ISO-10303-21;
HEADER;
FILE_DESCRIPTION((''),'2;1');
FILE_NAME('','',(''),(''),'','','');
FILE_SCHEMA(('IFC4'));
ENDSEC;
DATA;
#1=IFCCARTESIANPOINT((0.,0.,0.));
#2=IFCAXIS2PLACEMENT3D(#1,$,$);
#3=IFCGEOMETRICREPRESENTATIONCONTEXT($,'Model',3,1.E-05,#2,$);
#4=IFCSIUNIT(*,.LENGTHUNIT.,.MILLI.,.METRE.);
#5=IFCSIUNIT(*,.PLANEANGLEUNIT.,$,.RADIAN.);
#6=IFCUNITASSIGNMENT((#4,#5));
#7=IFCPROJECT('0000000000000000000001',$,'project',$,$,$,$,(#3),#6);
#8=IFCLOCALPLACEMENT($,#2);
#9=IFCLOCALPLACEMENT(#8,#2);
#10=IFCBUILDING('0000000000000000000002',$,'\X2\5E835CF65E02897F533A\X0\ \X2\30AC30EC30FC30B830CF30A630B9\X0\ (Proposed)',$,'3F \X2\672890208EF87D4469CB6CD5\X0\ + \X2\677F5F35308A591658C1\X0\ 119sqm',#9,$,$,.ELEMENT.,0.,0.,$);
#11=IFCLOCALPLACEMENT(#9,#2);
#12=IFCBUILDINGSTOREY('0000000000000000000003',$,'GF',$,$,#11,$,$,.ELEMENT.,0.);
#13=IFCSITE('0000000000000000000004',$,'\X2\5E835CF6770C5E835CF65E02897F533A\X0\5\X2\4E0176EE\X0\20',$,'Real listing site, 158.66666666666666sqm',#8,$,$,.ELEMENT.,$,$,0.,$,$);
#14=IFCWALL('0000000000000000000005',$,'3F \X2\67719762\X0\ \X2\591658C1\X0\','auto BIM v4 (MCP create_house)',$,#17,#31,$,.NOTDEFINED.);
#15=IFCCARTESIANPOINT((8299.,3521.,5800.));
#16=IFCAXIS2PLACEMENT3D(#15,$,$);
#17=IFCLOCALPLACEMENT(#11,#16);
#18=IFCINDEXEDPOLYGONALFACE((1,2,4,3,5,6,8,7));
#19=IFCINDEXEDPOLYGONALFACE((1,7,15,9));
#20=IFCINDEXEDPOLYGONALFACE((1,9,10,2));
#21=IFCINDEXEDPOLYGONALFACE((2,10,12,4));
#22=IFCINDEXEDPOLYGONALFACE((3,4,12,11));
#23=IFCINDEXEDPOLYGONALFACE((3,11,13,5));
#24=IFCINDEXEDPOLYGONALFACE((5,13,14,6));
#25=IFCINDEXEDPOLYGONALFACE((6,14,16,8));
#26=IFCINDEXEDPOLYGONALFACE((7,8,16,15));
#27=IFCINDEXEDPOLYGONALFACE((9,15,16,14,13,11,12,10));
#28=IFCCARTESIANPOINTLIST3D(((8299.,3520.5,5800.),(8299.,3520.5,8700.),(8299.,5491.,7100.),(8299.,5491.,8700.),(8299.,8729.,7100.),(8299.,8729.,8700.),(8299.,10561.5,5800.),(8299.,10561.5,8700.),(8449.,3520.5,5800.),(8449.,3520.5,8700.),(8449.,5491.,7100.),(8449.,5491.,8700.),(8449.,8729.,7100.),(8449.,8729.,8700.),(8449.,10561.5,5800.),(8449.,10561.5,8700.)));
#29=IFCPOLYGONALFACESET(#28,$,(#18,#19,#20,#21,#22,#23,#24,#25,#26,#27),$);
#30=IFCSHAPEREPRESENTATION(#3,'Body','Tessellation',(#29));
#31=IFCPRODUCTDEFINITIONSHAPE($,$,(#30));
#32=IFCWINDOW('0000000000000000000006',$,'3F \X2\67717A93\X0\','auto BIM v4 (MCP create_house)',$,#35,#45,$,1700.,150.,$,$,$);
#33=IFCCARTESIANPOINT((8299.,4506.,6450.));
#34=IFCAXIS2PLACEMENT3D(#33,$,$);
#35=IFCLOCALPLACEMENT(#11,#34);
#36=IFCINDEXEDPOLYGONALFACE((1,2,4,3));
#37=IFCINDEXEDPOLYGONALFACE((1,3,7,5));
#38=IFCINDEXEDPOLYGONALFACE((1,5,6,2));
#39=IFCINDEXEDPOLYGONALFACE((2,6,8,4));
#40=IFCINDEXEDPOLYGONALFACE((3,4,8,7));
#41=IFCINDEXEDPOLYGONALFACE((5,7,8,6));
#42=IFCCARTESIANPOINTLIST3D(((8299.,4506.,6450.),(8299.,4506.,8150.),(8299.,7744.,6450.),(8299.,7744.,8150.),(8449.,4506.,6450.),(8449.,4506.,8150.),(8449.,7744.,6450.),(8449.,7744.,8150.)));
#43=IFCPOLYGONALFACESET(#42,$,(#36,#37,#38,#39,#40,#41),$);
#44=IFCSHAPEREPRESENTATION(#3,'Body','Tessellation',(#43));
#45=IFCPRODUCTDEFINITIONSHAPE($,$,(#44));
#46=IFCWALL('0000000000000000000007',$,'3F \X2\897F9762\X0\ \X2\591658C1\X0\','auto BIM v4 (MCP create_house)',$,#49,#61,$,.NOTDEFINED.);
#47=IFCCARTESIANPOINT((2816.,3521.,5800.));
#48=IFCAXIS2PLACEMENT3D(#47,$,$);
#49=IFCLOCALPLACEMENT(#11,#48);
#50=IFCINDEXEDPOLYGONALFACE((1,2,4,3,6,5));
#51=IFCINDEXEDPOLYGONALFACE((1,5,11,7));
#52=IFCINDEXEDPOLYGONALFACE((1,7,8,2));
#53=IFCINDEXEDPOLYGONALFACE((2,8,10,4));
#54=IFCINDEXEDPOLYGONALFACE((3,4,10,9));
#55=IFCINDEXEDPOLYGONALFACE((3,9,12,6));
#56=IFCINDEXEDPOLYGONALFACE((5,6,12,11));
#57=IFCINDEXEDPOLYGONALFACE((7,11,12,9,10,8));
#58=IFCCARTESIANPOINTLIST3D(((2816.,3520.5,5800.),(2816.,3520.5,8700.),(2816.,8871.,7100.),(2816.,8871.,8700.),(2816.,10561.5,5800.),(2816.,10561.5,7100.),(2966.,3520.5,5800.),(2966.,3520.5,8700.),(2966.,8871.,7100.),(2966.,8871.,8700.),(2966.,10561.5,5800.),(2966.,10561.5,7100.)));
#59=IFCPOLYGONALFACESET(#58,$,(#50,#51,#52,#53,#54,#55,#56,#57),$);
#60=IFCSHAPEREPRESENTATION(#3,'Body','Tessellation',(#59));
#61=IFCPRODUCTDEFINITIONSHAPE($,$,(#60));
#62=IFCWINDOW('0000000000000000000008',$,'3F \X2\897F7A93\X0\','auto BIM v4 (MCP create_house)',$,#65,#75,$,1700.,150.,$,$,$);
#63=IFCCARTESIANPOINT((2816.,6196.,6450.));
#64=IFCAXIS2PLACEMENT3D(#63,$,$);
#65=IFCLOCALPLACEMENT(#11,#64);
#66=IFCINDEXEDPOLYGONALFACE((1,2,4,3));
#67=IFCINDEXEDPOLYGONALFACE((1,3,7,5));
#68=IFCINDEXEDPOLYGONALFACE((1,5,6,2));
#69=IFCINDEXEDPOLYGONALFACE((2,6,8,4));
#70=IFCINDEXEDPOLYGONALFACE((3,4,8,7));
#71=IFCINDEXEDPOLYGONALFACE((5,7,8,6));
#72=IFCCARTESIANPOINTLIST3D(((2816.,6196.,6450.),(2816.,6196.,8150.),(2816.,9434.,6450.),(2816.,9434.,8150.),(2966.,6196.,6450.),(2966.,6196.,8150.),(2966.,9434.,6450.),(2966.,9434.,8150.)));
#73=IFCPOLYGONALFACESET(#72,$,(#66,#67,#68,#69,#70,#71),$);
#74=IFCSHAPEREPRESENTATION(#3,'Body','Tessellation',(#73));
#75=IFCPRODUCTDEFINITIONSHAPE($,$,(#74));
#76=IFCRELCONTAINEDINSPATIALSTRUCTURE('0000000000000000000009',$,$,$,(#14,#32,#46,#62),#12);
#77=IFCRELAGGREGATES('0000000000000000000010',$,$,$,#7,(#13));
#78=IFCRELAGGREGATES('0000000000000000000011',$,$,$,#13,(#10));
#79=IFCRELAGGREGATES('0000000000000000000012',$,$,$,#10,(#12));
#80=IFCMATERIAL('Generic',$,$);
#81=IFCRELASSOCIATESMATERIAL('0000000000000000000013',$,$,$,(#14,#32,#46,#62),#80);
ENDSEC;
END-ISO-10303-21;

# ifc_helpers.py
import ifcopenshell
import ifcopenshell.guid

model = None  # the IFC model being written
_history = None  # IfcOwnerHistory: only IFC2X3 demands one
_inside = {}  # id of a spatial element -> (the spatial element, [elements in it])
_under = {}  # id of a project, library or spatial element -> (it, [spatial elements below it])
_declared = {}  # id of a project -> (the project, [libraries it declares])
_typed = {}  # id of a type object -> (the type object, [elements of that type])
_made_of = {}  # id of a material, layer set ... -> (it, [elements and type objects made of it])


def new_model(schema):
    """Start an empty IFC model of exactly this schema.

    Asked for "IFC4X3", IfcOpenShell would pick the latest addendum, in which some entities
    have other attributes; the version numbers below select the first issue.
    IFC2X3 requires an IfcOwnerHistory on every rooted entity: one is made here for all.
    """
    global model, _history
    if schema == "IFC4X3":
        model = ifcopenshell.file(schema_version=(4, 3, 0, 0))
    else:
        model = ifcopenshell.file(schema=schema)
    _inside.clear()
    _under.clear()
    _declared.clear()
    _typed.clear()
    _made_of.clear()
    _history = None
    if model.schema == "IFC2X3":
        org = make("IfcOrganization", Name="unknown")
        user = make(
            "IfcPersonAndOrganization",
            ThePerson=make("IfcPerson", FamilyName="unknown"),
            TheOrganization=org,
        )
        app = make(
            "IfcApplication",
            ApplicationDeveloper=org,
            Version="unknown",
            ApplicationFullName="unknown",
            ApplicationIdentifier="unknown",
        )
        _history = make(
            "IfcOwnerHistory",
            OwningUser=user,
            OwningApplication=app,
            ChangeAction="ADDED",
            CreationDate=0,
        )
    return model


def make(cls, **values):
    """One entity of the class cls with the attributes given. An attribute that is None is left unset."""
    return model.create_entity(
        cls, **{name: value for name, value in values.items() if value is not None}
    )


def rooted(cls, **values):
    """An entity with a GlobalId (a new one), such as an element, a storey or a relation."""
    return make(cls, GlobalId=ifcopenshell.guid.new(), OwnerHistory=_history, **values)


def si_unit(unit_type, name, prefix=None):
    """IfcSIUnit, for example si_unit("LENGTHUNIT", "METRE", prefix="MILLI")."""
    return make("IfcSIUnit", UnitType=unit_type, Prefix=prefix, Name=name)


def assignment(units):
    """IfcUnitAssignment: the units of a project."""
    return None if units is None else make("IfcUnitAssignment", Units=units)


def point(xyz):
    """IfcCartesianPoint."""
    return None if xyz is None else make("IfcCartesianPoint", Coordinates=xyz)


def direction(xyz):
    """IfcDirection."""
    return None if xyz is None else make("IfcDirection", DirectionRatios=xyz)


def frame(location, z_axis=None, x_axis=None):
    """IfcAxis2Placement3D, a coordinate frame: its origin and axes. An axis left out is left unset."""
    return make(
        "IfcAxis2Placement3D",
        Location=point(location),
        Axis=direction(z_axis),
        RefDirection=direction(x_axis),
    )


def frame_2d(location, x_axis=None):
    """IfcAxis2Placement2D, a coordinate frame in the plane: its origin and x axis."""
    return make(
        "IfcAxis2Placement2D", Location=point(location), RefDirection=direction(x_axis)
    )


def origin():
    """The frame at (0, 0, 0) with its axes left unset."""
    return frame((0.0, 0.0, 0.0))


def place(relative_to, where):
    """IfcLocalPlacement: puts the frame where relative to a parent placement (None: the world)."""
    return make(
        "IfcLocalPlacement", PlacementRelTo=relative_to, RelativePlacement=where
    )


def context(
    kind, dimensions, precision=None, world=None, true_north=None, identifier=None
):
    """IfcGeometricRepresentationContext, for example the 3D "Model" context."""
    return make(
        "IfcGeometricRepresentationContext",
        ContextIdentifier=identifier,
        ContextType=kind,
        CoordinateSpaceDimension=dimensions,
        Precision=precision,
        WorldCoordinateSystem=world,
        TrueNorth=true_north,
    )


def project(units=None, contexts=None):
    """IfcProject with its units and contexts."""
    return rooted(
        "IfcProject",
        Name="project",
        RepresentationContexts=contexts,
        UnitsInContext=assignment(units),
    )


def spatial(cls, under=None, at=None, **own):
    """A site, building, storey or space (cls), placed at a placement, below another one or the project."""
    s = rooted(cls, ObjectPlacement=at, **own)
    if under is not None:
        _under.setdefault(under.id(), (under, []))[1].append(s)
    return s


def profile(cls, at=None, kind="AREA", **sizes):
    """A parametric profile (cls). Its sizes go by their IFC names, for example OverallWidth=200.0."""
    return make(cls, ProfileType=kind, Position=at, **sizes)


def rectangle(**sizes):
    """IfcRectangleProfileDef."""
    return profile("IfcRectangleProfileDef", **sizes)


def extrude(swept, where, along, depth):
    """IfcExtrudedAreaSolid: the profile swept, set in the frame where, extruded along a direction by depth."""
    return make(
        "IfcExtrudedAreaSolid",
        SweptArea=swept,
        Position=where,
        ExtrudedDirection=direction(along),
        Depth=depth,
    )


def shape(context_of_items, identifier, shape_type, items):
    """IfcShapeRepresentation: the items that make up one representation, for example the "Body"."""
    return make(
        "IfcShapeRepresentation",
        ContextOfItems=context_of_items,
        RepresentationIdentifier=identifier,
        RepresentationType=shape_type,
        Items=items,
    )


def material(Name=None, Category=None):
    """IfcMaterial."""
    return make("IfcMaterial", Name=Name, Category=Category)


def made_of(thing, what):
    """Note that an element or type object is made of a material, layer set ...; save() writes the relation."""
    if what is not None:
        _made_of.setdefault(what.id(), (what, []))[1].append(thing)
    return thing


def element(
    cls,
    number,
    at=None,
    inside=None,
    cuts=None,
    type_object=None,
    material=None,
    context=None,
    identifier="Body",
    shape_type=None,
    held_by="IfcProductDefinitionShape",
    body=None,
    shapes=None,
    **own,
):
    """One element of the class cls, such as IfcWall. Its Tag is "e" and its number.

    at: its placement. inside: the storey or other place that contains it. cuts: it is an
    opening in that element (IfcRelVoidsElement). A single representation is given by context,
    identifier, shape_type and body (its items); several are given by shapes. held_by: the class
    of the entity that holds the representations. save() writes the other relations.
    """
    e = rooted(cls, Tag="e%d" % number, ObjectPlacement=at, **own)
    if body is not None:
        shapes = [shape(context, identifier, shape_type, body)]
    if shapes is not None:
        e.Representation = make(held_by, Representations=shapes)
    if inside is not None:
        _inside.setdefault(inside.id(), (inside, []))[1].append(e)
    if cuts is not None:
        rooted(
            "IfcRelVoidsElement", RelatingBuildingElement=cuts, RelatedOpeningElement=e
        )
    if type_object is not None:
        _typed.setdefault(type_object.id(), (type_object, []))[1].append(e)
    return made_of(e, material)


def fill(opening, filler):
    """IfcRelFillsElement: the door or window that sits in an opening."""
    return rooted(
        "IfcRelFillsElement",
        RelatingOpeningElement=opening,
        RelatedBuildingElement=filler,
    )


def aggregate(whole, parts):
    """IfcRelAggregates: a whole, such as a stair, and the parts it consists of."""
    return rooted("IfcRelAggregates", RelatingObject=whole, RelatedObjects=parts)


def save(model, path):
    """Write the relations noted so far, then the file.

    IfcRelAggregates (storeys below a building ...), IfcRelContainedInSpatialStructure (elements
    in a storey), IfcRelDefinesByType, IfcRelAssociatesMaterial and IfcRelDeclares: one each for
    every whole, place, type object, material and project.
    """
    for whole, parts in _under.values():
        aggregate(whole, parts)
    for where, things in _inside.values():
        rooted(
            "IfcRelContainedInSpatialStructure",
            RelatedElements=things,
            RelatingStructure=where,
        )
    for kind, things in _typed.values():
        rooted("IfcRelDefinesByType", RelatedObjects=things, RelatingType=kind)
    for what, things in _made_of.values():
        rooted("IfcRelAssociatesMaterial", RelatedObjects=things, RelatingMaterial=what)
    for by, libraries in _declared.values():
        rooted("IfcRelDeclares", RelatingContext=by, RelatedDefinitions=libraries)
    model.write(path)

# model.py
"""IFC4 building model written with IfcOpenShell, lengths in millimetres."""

from ifc_helpers import new_model, si_unit, frame, frame_2d, origin, place, context, project, spatial, rectangle, extrude, material, element, fill, save


model = new_model("IFC4")

# Units and contexts
model_context = context("Model", 3, precision=1e-05, world=origin())
ifc_project = project(units=[si_unit("LENGTHUNIT", "METRE", prefix="MILLI"), si_unit("PLANEANGLEUNIT", "RADIAN")], contexts=[model_context])

# Site, building, storey
site_placement = place(None, origin())
site = spatial("IfcSite", under=ifc_project, at=site_placement, Name="広島県広島市西区5丁目20", ObjectType="Real listing site, 158.66666666666666sqm", CompositionType="ELEMENT", RefElevation=0.0)
building_placement = place(site_placement, origin())
building = spatial("IfcBuilding", under=site, at=building_placement, Name="広島市西区 ガレージハウス (Proposed)", ObjectType="3F 木造軸組構法 + 板張り外壁 119sqm", CompositionType="ELEMENT", ElevationOfRefHeight=0.0, ElevationOfTerrain=0.0)
storey_placement = place(building_placement, origin())
storey = spatial("IfcBuildingStorey", under=building, at=storey_placement, Name="GF", CompositionType="ELEMENT", Elevation=0.0)

# Shared definitions
ifc_material = material(Name="Generic")

# Walls, openings, windows
wall_1_placement = place(storey_placement, frame((8299.0, 3521.0, 5800.0)))
wall_1 = element("IfcWall", 1, at=wall_1_placement, inside=storey, material=ifc_material, Name="3F 東面 外壁", Description="auto BIM v4 (MCP create_house)", PredefinedType="NOTDEFINED", context=model_context, shape_type="SweptSolid", body=[
    extrude(rectangle(XDim=150.0, YDim=7041.0, at=frame_2d((75.0, 3520.0))), frame((8299.0, 3521.0, 5800.0)), (0.0, 0.0, 1.0), 2900.0),
])
opening_1_placement = place(storey_placement, frame((8299.0, 4506.0, 6450.0)))
opening_1 = element("IfcOpeningElement", 2, at=opening_1_placement, cuts=wall_1, PredefinedType="NOTDEFINED", context=model_context, shape_type="SweptSolid", body=[
    extrude(rectangle(XDim=150.0, YDim=3238.0, at=frame_2d((75.0, 1619.0))), frame((8299.0, 4506.0, 6450.0)), (0.0, 0.0, 1.0), 1700.0),
])
window_1_placement = place(storey_placement, frame((8299.0, 4506.0, 6450.0)))
window_1 = element("IfcWindow", 3, at=window_1_placement, inside=storey, material=ifc_material, Name="3F 東窓", Description="auto BIM v4 (MCP create_house)", OverallHeight=1700.0, OverallWidth=150.0, context=model_context, shape_type="SweptSolid", body=[
    extrude(rectangle(XDim=150.0, YDim=3238.0, at=frame_2d((75.0, 1619.0))), frame((8299.0, 4506.0, 6450.0)), (0.0, 0.0, 1.0), 1700.0),
])
fill(opening_1, window_1)
wall_2_placement = place(storey_placement, frame((2816.0, 3521.0, 5800.0)))
wall_2 = element("IfcWall", 4, at=wall_2_placement, inside=storey, material=ifc_material, Name="3F 西面 外壁", Description="auto BIM v4 (MCP create_house)", PredefinedType="NOTDEFINED", context=model_context, shape_type="SweptSolid", body=[
    extrude(rectangle(XDim=150.0, YDim=7041.0, at=frame_2d((75.0, 3520.0))), frame((2816.0, 3521.0, 5800.0)), (0.0, 0.0, 1.0), 2900.0),
])
opening_2_placement = place(storey_placement, frame((2816.0, 6196.0, 6450.0)))
opening_2 = element("IfcOpeningElement", 5, at=opening_2_placement, cuts=wall_2, PredefinedType="NOTDEFINED", context=model_context, shape_type="SweptSolid", body=[
    extrude(rectangle(XDim=150.0, YDim=3238.0, at=frame_2d((75.0, 1619.0))), frame((2816.0, 6196.0, 6450.0)), (0.0, 0.0, 1.0), 1700.0),
])
window_2_placement = place(storey_placement, frame((2816.0, 6196.0, 6450.0)))
window_2 = element("IfcWindow", 6, at=window_2_placement, inside=storey, material=ifc_material, Name="3F 西窓", Description="auto BIM v4 (MCP create_house)", OverallHeight=1700.0, OverallWidth=150.0, context=model_context, shape_type="SweptSolid", body=[
    extrude(rectangle(XDim=150.0, YDim=3238.0, at=frame_2d((75.0, 1619.0))), frame((2816.0, 6196.0, 6450.0)), (0.0, 0.0, 1.0), 1700.0),
])
fill(opening_2, window_2)

save(model, "model.ifc")
